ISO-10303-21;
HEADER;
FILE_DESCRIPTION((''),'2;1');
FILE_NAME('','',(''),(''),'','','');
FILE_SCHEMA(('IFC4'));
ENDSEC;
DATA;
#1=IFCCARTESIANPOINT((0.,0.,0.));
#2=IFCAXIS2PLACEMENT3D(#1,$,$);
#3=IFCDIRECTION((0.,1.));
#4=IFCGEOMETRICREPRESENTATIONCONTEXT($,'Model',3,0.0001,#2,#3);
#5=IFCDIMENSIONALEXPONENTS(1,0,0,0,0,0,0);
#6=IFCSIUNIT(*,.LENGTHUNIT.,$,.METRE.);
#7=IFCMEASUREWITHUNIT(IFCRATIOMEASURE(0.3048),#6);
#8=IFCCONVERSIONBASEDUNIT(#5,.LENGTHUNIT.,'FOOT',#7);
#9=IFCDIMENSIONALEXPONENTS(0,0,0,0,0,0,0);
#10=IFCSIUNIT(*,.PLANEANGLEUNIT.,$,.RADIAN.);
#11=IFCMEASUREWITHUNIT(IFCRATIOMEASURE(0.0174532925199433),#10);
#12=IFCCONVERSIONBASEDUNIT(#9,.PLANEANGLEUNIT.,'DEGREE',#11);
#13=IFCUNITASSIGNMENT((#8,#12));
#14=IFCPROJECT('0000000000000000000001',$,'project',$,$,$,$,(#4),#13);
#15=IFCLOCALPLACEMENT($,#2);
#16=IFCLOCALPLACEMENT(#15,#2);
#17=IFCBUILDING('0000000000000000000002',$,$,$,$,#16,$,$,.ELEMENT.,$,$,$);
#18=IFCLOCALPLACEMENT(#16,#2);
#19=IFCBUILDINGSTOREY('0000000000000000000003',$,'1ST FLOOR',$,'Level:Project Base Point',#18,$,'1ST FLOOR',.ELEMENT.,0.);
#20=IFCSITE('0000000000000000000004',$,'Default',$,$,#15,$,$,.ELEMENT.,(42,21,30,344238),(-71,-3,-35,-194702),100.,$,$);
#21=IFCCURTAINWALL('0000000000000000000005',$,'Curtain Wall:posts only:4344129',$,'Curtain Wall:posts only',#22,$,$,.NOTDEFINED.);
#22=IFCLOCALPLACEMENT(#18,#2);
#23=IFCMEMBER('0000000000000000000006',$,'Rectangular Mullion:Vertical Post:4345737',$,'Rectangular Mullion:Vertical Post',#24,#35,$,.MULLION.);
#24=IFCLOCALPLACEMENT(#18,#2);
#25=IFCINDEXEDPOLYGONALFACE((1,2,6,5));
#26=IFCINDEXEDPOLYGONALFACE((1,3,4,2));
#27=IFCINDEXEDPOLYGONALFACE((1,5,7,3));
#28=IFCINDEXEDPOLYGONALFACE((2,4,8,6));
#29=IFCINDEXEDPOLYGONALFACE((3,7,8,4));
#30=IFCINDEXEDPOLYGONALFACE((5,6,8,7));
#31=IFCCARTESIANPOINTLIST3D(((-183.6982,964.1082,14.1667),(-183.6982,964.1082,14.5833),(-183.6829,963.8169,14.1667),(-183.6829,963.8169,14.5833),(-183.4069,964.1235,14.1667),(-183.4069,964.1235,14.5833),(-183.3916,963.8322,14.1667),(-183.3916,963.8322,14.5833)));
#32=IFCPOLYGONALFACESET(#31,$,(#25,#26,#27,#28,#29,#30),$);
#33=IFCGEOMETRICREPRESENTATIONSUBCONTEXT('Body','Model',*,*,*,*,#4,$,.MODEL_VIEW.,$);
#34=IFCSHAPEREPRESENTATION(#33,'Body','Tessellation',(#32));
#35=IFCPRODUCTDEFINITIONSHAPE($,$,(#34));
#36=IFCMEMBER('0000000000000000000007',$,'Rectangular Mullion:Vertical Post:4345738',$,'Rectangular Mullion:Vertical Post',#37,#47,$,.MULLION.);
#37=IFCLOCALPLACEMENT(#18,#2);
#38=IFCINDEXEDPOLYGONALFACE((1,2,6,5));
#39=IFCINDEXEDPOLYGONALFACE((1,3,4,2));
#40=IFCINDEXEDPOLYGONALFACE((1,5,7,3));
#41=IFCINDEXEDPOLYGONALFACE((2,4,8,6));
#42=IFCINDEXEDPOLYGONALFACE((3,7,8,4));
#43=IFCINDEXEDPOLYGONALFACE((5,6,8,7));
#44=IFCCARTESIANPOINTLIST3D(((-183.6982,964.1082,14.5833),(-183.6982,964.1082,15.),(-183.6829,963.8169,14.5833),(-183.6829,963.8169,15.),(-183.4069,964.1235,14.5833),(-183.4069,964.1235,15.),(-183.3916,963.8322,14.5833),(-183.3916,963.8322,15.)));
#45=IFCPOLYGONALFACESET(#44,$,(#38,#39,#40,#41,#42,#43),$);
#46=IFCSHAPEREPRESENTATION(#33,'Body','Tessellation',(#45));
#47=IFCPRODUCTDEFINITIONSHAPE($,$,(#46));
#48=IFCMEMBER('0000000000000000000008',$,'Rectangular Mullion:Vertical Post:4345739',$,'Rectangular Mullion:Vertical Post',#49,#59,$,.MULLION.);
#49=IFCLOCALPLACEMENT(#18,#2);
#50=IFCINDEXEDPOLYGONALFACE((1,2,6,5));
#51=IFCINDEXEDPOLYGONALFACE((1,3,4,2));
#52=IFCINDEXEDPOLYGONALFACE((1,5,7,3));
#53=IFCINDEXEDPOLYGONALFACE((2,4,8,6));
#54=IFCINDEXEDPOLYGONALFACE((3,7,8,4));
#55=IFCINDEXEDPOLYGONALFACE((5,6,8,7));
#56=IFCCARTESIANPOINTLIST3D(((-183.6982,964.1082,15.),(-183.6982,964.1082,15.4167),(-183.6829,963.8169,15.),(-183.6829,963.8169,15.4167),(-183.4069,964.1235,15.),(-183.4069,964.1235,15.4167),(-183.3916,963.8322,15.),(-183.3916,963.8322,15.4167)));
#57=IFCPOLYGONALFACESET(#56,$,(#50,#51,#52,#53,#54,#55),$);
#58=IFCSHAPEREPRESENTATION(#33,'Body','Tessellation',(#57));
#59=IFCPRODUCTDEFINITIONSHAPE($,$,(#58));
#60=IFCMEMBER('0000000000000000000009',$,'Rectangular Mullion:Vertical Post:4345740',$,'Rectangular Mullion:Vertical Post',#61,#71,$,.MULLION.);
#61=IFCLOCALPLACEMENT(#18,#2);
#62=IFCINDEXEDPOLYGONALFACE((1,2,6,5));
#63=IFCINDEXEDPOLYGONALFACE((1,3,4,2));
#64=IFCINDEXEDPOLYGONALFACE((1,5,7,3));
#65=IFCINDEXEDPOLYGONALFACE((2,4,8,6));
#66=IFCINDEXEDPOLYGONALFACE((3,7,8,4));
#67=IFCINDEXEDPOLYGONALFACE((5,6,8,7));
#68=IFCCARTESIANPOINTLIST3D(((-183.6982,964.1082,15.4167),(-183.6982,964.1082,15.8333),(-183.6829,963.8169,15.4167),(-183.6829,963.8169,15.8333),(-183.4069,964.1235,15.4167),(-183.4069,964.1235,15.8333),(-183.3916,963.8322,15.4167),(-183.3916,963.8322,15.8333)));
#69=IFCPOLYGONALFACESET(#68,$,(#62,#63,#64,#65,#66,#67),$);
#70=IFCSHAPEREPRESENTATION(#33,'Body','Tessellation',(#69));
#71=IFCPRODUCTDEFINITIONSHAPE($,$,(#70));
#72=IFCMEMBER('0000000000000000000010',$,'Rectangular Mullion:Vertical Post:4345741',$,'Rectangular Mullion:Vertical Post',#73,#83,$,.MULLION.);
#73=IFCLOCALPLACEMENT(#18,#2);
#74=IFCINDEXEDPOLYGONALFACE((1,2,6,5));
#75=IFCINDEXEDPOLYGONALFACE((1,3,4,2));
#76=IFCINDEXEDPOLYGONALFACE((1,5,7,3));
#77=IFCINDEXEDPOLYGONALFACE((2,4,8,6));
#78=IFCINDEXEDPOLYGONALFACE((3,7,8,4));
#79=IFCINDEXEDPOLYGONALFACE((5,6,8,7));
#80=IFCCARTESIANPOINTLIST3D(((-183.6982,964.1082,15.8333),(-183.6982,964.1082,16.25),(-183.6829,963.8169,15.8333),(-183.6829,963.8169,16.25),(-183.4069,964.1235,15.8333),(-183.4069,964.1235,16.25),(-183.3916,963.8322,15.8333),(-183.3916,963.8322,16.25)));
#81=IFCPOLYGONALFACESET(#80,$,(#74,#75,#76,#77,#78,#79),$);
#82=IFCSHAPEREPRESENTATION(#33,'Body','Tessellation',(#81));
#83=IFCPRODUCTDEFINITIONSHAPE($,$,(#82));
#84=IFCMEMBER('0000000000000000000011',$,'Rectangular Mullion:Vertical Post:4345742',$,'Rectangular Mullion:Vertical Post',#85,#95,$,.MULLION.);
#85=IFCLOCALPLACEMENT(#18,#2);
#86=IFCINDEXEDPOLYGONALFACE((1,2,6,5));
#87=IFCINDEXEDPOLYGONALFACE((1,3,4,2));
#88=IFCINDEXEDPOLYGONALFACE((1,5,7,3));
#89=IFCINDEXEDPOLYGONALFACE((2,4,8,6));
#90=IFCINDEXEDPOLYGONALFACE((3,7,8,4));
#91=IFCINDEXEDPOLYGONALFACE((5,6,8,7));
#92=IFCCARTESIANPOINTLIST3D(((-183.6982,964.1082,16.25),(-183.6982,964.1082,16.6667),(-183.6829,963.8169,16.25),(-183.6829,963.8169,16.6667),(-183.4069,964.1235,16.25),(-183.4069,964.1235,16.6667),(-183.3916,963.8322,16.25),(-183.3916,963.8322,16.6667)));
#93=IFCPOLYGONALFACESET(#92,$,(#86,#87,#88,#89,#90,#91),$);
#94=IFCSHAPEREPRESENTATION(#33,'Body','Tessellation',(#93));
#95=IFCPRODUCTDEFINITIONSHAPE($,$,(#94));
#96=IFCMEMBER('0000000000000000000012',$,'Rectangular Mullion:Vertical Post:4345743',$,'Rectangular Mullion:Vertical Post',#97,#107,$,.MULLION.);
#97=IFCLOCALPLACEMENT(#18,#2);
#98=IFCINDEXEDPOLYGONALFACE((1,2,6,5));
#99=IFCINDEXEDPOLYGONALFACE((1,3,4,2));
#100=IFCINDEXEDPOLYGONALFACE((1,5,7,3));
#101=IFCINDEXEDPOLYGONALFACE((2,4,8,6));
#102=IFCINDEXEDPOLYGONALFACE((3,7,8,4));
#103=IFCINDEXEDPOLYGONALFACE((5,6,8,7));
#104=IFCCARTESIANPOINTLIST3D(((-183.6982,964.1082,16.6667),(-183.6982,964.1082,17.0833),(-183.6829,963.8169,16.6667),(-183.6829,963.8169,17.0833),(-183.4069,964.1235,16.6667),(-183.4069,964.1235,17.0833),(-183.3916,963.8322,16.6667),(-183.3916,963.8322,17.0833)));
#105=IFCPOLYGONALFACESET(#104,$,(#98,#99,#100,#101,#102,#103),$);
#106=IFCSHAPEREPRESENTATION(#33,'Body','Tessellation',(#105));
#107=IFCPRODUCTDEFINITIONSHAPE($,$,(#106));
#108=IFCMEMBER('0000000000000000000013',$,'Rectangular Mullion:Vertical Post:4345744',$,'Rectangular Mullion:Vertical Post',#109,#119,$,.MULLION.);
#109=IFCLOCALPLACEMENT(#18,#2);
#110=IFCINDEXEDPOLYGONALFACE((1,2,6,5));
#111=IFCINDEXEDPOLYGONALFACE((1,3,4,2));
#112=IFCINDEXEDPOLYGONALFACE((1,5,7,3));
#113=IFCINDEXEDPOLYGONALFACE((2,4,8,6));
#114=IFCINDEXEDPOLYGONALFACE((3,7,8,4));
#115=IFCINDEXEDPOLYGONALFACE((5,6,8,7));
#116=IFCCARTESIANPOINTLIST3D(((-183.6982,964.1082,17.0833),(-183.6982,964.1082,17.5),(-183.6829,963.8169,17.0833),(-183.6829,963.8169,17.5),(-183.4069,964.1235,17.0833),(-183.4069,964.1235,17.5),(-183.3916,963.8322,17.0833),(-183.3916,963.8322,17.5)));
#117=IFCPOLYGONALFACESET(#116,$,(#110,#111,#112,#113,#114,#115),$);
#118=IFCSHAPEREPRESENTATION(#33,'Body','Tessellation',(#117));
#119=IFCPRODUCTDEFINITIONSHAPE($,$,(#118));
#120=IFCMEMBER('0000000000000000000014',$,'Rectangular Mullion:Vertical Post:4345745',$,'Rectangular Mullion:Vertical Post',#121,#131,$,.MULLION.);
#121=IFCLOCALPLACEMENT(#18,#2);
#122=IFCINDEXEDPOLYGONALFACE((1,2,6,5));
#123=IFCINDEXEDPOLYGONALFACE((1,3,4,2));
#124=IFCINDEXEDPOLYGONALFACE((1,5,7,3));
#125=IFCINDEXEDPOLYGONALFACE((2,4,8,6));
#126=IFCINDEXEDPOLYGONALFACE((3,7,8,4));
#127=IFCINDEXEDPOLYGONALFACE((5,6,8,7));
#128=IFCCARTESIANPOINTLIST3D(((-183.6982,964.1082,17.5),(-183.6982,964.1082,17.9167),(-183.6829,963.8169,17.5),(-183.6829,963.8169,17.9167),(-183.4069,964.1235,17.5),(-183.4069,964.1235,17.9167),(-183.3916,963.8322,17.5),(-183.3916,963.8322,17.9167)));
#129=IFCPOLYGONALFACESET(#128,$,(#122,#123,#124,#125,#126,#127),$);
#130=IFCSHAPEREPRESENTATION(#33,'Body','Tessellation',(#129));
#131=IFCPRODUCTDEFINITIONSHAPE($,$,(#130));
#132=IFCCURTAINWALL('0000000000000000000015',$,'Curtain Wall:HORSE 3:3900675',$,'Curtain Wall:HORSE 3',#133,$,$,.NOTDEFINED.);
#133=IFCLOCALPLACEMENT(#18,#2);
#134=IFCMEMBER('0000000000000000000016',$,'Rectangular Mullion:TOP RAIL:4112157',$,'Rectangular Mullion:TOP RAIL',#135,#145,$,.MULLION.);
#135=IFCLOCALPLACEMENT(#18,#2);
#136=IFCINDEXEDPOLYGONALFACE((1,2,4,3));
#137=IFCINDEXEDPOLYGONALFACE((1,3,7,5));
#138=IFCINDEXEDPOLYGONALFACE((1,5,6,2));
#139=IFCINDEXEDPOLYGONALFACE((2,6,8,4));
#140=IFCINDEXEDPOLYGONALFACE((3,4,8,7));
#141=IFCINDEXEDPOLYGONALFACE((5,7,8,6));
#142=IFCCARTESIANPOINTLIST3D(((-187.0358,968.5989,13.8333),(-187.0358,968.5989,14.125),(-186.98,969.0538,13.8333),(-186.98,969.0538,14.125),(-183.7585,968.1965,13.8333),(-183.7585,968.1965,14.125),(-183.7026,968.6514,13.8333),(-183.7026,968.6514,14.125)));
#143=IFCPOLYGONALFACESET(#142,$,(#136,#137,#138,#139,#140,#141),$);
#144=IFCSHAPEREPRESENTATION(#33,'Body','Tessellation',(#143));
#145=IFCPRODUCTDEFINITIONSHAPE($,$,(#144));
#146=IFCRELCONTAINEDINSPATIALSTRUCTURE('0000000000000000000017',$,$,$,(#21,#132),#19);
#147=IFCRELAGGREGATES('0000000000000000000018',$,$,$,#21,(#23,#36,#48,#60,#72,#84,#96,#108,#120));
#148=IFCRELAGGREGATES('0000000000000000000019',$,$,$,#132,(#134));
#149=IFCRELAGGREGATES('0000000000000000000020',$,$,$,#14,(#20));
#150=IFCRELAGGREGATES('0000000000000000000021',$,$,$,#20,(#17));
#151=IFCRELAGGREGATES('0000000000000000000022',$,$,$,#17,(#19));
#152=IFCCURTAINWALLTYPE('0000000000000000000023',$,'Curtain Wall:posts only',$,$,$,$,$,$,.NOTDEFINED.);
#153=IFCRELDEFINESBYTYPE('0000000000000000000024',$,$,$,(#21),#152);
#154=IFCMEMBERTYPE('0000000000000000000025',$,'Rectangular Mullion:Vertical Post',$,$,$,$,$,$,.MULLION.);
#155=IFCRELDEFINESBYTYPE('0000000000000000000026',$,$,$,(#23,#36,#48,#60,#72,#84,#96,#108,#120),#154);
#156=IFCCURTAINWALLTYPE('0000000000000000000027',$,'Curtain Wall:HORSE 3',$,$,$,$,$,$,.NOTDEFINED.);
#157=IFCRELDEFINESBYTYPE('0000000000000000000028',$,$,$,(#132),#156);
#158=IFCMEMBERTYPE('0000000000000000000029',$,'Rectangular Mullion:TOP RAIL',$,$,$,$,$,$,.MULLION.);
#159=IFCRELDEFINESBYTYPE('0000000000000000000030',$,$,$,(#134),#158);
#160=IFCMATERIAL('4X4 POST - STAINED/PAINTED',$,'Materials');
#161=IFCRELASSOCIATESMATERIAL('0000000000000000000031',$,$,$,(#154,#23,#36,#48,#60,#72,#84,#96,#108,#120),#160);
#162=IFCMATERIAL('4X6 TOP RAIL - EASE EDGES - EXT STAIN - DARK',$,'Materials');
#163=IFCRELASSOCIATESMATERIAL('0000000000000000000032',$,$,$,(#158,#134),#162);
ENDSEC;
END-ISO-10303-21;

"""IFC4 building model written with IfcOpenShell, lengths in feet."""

from ifc_helpers import new_model, entity, si_unit, converted_unit, direction, frame, origin, origin_2d_with_axis, place, context, subcontext, project, spatial, rectangle, extrude, source, transform, mapped, material, material_profile, profile_set, profile_usage, type_object, type_shapes, element, aggregate, save


model = new_model("IFC4")

# Units and contexts
model_context = context("Model", 3, precision=0.0001, world=origin(), true_north=direction((0.0, 1.0)))
body_context = subcontext(model_context, "Body", "Model", "MODEL_VIEW")
ifc_project = project(units=[converted_unit("LENGTHUNIT", "FOOT", entity("IfcRatioMeasure", 0.3048), si_unit("LENGTHUNIT", "METRE"), dimensions=[1, 0, 0, 0, 0, 0, 0]), converted_unit("PLANEANGLEUNIT", "DEGREE", entity("IfcRatioMeasure", 0.0174532925199433), si_unit("PLANEANGLEUNIT", "RADIAN"), dimensions=[0, 0, 0, 0, 0, 0, 0])], contexts=[model_context])

# Site, building, storey
site_placement = place(None, origin())
site = spatial("IfcSite", under=ifc_project, at=site_placement, Name="Default", CompositionType="ELEMENT", RefLatitude=(42, 21, 30, 344238), RefLongitude=(-71, -3, -35, -194702), RefElevation=100.0)
building_placement = place(site_placement, origin())
building = spatial("IfcBuilding", under=site, at=building_placement, CompositionType="ELEMENT")
storey_placement = place(building_placement, origin())
storey = spatial("IfcBuildingStorey", under=building, at=storey_placement, Name="1ST FLOOR", ObjectType="Level:Project Base Point", LongName="1ST FLOOR", CompositionType="ELEMENT", Elevation=0.0)

# Curtain walls, members
curtain_wall_type_1 = type_object("IfcCurtainWallType", Name="Curtain Wall:posts only", PredefinedType="NOTDEFINED")
curtain_wall_1_placement = place(storey_placement, origin())
curtain_wall_1 = element("IfcCurtainWall", 1, at=curtain_wall_1_placement, inside=storey, type_object=curtain_wall_type_1, Name="Curtain Wall:posts only:4344129", ObjectType="Curtain Wall:posts only", PredefinedType="NOTDEFINED")
ifc_material_1 = material(Name="4X4 POST - STAINED/PAINTED", Category="Materials")
ifc_material_profile_1 = material_profile(ifc_material_1, rectangle(XDim=0.2917, YDim=0.2917, at=origin_2d_with_axis()), Name="Vertical Post")
ifc_profile_set_1 = profile_set([ifc_material_profile_1], Name="Vertical Post")
member_type_1 = type_object("IfcMemberType", Name="Rectangular Mullion:Vertical Post", PredefinedType="MULLION", material=ifc_profile_set_1)
shared_shape_1 = source(origin(), body_context, "Body", "SweptSolid", [
    extrude(rectangle(XDim=0.2917, YDim=0.2917, at=origin_2d_with_axis()), frame((0.0, -0.2083, -0.4167), z_axis=(0.0, 0.0, 1.0), x_axis=(0.0, -1.0, 0.0)), (0.0, 0.0, 1.0), 0.4167),
])
type_shapes(member_type_1, [shared_shape_1])
ifc_profile_usage_1 = profile_usage(ifc_profile_set_1)
member_1_placement = place(storey_placement, frame((-183.5558, 964.1782, 14.1667), z_axis=(0.0, 0.0, -1.0), x_axis=(-0.99863, -0.052336, 0.0)))
member_1 = element("IfcMember", 2, at=member_1_placement, type_object=member_type_1, material=ifc_profile_usage_1, Name="Rectangular Mullion:Vertical Post:4345737", ObjectType="Rectangular Mullion:Vertical Post", PredefinedType="MULLION", context=body_context, shape_type="MappedRepresentation", body=[
    mapped(shared_shape_1, transform((0.0, 0.0, 0.0), scale=1.0)),
])
ifc_profile_usage_2 = profile_usage(ifc_profile_set_1)
member_2_placement = place(storey_placement, frame((-183.5558, 964.1782, 14.5833), z_axis=(0.0, 0.0, -1.0), x_axis=(-0.99863, -0.052336, 0.0)))
member_2 = element("IfcMember", 3, at=member_2_placement, type_object=member_type_1, material=ifc_profile_usage_2, Name="Rectangular Mullion:Vertical Post:4345738", ObjectType="Rectangular Mullion:Vertical Post", PredefinedType="MULLION", context=body_context, shape_type="MappedRepresentation", body=[
    mapped(shared_shape_1, transform((0.0, 0.0, 0.0), scale=1.0)),
])
ifc_profile_usage_3 = profile_usage(ifc_profile_set_1)
member_3_placement = place(storey_placement, frame((-183.5558, 964.1782, 15.0), z_axis=(0.0, 0.0, -1.0), x_axis=(-0.99863, -0.052336, 0.0)))
member_3 = element("IfcMember", 4, at=member_3_placement, type_object=member_type_1, material=ifc_profile_usage_3, Name="Rectangular Mullion:Vertical Post:4345739", ObjectType="Rectangular Mullion:Vertical Post", PredefinedType="MULLION", context=body_context, shape_type="MappedRepresentation", body=[
    mapped(shared_shape_1, transform((0.0, 0.0, 0.0), scale=1.0)),
])
ifc_profile_usage_4 = profile_usage(ifc_profile_set_1)
member_4_placement = place(storey_placement, frame((-183.5558, 964.1782, 15.4167), z_axis=(0.0, 0.0, -1.0), x_axis=(-0.99863, -0.052336, 0.0)))
member_4 = element("IfcMember", 5, at=member_4_placement, type_object=member_type_1, material=ifc_profile_usage_4, Name="Rectangular Mullion:Vertical Post:4345740", ObjectType="Rectangular Mullion:Vertical Post", PredefinedType="MULLION", context=body_context, shape_type="MappedRepresentation", body=[
    mapped(shared_shape_1, transform((0.0, 0.0, 0.0), scale=1.0)),
])
ifc_profile_usage_5 = profile_usage(ifc_profile_set_1)
member_5_placement = place(storey_placement, frame((-183.5558, 964.1782, 15.8333), z_axis=(0.0, 0.0, -1.0), x_axis=(-0.99863, -0.052336, 0.0)))
member_5 = element("IfcMember", 6, at=member_5_placement, type_object=member_type_1, material=ifc_profile_usage_5, Name="Rectangular Mullion:Vertical Post:4345741", ObjectType="Rectangular Mullion:Vertical Post", PredefinedType="MULLION", context=body_context, shape_type="MappedRepresentation", body=[
    mapped(shared_shape_1, transform((0.0, 0.0, 0.0), scale=1.0)),
])
ifc_profile_usage_6 = profile_usage(ifc_profile_set_1)
member_6_placement = place(storey_placement, frame((-183.5558, 964.1782, 16.25), z_axis=(0.0, 0.0, -1.0), x_axis=(-0.99863, -0.052336, 0.0)))
member_6 = element("IfcMember", 7, at=member_6_placement, type_object=member_type_1, material=ifc_profile_usage_6, Name="Rectangular Mullion:Vertical Post:4345742", ObjectType="Rectangular Mullion:Vertical Post", PredefinedType="MULLION", context=body_context, shape_type="MappedRepresentation", body=[
    mapped(shared_shape_1, transform((0.0, 0.0, 0.0), scale=1.0)),
])
ifc_profile_usage_7 = profile_usage(ifc_profile_set_1)
member_7_placement = place(storey_placement, frame((-183.5558, 964.1782, 16.6667), z_axis=(0.0, 0.0, -1.0), x_axis=(-0.99863, -0.052336, 0.0)))
member_7 = element("IfcMember", 8, at=member_7_placement, type_object=member_type_1, material=ifc_profile_usage_7, Name="Rectangular Mullion:Vertical Post:4345743", ObjectType="Rectangular Mullion:Vertical Post", PredefinedType="MULLION", context=body_context, shape_type="MappedRepresentation", body=[
    mapped(shared_shape_1, transform((0.0, 0.0, 0.0), scale=1.0)),
])
ifc_profile_usage_8 = profile_usage(ifc_profile_set_1)
member_8_placement = place(storey_placement, frame((-183.5558, 964.1782, 17.0833), z_axis=(0.0, 0.0, -1.0), x_axis=(-0.99863, -0.052336, 0.0)))
member_8 = element("IfcMember", 9, at=member_8_placement, type_object=member_type_1, material=ifc_profile_usage_8, Name="Rectangular Mullion:Vertical Post:4345744", ObjectType="Rectangular Mullion:Vertical Post", PredefinedType="MULLION", context=body_context, shape_type="MappedRepresentation", body=[
    mapped(shared_shape_1, transform((0.0, 0.0, 0.0), scale=1.0)),
])
ifc_profile_usage_9 = profile_usage(ifc_profile_set_1)
member_9_placement = place(storey_placement, frame((-183.5558, 964.1782, 17.5), z_axis=(0.0, 0.0, -1.0), x_axis=(-0.99863, -0.052336, 0.0)))
member_9 = element("IfcMember", 10, at=member_9_placement, type_object=member_type_1, material=ifc_profile_usage_9, Name="Rectangular Mullion:Vertical Post:4345745", ObjectType="Rectangular Mullion:Vertical Post", PredefinedType="MULLION", context=body_context, shape_type="MappedRepresentation", body=[
    mapped(shared_shape_1, transform((0.0, 0.0, 0.0), scale=1.0)),
])
aggregate(curtain_wall_1, [member_1, member_2, member_3, member_4, member_5, member_6, member_7, member_8, member_9])
curtain_wall_type_2 = type_object("IfcCurtainWallType", Name="Curtain Wall:HORSE 3", PredefinedType="NOTDEFINED")
curtain_wall_2_placement = place(storey_placement, origin())
curtain_wall_2 = element("IfcCurtainWall", 11, at=curtain_wall_2_placement, inside=storey, type_object=curtain_wall_type_2, Name="Curtain Wall:HORSE 3:3900675", ObjectType="Curtain Wall:HORSE 3", PredefinedType="NOTDEFINED")
ifc_material_2 = material(Name="4X6 TOP RAIL - EASE EDGES - EXT STAIN - DARK", Category="Materials")
ifc_material_profile_2 = material_profile(ifc_material_2, rectangle(XDim=0.4583, YDim=0.2917, at=origin_2d_with_axis()), Name="TOP RAIL")
ifc_profile_set_2 = profile_set([ifc_material_profile_2], Name="TOP RAIL")
ifc_profile_usage_10 = profile_usage(ifc_profile_set_2)
member_type_2 = type_object("IfcMemberType", Name="Rectangular Mullion:TOP RAIL", PredefinedType="MULLION", material=ifc_profile_set_2)
shared_shape_2 = source(origin(), body_context, "Body", "SweptSolid", [
    extrude(rectangle(XDim=0.4583, YDim=0.2917, at=origin_2d_with_axis()), frame((-0.1458, -0.0625, -3.302), z_axis=(0.0, 0.0, 1.0), x_axis=(0.0, -1.0, 0.0)), (0.0, 0.0, 1.0), 3.302),
])
type_shapes(member_type_2, [shared_shape_2])
member_10_placement = place(storey_placement, frame((-183.7382, 968.3619, 14.125), z_axis=(0.992546, -0.121869, 0.0), x_axis=(0.0, 0.0, 1.0)))
member_10 = element("IfcMember", 12, at=member_10_placement, type_object=member_type_2, material=ifc_profile_usage_10, Name="Rectangular Mullion:TOP RAIL:4112157", ObjectType="Rectangular Mullion:TOP RAIL", PredefinedType="MULLION", context=body_context, shape_type="MappedRepresentation", body=[
    mapped(shared_shape_2, transform((0.0, 0.0, 0.0), scale=1.0)),
])
aggregate(curtain_wall_2, [member_10])

save(model, "model.ifc")
